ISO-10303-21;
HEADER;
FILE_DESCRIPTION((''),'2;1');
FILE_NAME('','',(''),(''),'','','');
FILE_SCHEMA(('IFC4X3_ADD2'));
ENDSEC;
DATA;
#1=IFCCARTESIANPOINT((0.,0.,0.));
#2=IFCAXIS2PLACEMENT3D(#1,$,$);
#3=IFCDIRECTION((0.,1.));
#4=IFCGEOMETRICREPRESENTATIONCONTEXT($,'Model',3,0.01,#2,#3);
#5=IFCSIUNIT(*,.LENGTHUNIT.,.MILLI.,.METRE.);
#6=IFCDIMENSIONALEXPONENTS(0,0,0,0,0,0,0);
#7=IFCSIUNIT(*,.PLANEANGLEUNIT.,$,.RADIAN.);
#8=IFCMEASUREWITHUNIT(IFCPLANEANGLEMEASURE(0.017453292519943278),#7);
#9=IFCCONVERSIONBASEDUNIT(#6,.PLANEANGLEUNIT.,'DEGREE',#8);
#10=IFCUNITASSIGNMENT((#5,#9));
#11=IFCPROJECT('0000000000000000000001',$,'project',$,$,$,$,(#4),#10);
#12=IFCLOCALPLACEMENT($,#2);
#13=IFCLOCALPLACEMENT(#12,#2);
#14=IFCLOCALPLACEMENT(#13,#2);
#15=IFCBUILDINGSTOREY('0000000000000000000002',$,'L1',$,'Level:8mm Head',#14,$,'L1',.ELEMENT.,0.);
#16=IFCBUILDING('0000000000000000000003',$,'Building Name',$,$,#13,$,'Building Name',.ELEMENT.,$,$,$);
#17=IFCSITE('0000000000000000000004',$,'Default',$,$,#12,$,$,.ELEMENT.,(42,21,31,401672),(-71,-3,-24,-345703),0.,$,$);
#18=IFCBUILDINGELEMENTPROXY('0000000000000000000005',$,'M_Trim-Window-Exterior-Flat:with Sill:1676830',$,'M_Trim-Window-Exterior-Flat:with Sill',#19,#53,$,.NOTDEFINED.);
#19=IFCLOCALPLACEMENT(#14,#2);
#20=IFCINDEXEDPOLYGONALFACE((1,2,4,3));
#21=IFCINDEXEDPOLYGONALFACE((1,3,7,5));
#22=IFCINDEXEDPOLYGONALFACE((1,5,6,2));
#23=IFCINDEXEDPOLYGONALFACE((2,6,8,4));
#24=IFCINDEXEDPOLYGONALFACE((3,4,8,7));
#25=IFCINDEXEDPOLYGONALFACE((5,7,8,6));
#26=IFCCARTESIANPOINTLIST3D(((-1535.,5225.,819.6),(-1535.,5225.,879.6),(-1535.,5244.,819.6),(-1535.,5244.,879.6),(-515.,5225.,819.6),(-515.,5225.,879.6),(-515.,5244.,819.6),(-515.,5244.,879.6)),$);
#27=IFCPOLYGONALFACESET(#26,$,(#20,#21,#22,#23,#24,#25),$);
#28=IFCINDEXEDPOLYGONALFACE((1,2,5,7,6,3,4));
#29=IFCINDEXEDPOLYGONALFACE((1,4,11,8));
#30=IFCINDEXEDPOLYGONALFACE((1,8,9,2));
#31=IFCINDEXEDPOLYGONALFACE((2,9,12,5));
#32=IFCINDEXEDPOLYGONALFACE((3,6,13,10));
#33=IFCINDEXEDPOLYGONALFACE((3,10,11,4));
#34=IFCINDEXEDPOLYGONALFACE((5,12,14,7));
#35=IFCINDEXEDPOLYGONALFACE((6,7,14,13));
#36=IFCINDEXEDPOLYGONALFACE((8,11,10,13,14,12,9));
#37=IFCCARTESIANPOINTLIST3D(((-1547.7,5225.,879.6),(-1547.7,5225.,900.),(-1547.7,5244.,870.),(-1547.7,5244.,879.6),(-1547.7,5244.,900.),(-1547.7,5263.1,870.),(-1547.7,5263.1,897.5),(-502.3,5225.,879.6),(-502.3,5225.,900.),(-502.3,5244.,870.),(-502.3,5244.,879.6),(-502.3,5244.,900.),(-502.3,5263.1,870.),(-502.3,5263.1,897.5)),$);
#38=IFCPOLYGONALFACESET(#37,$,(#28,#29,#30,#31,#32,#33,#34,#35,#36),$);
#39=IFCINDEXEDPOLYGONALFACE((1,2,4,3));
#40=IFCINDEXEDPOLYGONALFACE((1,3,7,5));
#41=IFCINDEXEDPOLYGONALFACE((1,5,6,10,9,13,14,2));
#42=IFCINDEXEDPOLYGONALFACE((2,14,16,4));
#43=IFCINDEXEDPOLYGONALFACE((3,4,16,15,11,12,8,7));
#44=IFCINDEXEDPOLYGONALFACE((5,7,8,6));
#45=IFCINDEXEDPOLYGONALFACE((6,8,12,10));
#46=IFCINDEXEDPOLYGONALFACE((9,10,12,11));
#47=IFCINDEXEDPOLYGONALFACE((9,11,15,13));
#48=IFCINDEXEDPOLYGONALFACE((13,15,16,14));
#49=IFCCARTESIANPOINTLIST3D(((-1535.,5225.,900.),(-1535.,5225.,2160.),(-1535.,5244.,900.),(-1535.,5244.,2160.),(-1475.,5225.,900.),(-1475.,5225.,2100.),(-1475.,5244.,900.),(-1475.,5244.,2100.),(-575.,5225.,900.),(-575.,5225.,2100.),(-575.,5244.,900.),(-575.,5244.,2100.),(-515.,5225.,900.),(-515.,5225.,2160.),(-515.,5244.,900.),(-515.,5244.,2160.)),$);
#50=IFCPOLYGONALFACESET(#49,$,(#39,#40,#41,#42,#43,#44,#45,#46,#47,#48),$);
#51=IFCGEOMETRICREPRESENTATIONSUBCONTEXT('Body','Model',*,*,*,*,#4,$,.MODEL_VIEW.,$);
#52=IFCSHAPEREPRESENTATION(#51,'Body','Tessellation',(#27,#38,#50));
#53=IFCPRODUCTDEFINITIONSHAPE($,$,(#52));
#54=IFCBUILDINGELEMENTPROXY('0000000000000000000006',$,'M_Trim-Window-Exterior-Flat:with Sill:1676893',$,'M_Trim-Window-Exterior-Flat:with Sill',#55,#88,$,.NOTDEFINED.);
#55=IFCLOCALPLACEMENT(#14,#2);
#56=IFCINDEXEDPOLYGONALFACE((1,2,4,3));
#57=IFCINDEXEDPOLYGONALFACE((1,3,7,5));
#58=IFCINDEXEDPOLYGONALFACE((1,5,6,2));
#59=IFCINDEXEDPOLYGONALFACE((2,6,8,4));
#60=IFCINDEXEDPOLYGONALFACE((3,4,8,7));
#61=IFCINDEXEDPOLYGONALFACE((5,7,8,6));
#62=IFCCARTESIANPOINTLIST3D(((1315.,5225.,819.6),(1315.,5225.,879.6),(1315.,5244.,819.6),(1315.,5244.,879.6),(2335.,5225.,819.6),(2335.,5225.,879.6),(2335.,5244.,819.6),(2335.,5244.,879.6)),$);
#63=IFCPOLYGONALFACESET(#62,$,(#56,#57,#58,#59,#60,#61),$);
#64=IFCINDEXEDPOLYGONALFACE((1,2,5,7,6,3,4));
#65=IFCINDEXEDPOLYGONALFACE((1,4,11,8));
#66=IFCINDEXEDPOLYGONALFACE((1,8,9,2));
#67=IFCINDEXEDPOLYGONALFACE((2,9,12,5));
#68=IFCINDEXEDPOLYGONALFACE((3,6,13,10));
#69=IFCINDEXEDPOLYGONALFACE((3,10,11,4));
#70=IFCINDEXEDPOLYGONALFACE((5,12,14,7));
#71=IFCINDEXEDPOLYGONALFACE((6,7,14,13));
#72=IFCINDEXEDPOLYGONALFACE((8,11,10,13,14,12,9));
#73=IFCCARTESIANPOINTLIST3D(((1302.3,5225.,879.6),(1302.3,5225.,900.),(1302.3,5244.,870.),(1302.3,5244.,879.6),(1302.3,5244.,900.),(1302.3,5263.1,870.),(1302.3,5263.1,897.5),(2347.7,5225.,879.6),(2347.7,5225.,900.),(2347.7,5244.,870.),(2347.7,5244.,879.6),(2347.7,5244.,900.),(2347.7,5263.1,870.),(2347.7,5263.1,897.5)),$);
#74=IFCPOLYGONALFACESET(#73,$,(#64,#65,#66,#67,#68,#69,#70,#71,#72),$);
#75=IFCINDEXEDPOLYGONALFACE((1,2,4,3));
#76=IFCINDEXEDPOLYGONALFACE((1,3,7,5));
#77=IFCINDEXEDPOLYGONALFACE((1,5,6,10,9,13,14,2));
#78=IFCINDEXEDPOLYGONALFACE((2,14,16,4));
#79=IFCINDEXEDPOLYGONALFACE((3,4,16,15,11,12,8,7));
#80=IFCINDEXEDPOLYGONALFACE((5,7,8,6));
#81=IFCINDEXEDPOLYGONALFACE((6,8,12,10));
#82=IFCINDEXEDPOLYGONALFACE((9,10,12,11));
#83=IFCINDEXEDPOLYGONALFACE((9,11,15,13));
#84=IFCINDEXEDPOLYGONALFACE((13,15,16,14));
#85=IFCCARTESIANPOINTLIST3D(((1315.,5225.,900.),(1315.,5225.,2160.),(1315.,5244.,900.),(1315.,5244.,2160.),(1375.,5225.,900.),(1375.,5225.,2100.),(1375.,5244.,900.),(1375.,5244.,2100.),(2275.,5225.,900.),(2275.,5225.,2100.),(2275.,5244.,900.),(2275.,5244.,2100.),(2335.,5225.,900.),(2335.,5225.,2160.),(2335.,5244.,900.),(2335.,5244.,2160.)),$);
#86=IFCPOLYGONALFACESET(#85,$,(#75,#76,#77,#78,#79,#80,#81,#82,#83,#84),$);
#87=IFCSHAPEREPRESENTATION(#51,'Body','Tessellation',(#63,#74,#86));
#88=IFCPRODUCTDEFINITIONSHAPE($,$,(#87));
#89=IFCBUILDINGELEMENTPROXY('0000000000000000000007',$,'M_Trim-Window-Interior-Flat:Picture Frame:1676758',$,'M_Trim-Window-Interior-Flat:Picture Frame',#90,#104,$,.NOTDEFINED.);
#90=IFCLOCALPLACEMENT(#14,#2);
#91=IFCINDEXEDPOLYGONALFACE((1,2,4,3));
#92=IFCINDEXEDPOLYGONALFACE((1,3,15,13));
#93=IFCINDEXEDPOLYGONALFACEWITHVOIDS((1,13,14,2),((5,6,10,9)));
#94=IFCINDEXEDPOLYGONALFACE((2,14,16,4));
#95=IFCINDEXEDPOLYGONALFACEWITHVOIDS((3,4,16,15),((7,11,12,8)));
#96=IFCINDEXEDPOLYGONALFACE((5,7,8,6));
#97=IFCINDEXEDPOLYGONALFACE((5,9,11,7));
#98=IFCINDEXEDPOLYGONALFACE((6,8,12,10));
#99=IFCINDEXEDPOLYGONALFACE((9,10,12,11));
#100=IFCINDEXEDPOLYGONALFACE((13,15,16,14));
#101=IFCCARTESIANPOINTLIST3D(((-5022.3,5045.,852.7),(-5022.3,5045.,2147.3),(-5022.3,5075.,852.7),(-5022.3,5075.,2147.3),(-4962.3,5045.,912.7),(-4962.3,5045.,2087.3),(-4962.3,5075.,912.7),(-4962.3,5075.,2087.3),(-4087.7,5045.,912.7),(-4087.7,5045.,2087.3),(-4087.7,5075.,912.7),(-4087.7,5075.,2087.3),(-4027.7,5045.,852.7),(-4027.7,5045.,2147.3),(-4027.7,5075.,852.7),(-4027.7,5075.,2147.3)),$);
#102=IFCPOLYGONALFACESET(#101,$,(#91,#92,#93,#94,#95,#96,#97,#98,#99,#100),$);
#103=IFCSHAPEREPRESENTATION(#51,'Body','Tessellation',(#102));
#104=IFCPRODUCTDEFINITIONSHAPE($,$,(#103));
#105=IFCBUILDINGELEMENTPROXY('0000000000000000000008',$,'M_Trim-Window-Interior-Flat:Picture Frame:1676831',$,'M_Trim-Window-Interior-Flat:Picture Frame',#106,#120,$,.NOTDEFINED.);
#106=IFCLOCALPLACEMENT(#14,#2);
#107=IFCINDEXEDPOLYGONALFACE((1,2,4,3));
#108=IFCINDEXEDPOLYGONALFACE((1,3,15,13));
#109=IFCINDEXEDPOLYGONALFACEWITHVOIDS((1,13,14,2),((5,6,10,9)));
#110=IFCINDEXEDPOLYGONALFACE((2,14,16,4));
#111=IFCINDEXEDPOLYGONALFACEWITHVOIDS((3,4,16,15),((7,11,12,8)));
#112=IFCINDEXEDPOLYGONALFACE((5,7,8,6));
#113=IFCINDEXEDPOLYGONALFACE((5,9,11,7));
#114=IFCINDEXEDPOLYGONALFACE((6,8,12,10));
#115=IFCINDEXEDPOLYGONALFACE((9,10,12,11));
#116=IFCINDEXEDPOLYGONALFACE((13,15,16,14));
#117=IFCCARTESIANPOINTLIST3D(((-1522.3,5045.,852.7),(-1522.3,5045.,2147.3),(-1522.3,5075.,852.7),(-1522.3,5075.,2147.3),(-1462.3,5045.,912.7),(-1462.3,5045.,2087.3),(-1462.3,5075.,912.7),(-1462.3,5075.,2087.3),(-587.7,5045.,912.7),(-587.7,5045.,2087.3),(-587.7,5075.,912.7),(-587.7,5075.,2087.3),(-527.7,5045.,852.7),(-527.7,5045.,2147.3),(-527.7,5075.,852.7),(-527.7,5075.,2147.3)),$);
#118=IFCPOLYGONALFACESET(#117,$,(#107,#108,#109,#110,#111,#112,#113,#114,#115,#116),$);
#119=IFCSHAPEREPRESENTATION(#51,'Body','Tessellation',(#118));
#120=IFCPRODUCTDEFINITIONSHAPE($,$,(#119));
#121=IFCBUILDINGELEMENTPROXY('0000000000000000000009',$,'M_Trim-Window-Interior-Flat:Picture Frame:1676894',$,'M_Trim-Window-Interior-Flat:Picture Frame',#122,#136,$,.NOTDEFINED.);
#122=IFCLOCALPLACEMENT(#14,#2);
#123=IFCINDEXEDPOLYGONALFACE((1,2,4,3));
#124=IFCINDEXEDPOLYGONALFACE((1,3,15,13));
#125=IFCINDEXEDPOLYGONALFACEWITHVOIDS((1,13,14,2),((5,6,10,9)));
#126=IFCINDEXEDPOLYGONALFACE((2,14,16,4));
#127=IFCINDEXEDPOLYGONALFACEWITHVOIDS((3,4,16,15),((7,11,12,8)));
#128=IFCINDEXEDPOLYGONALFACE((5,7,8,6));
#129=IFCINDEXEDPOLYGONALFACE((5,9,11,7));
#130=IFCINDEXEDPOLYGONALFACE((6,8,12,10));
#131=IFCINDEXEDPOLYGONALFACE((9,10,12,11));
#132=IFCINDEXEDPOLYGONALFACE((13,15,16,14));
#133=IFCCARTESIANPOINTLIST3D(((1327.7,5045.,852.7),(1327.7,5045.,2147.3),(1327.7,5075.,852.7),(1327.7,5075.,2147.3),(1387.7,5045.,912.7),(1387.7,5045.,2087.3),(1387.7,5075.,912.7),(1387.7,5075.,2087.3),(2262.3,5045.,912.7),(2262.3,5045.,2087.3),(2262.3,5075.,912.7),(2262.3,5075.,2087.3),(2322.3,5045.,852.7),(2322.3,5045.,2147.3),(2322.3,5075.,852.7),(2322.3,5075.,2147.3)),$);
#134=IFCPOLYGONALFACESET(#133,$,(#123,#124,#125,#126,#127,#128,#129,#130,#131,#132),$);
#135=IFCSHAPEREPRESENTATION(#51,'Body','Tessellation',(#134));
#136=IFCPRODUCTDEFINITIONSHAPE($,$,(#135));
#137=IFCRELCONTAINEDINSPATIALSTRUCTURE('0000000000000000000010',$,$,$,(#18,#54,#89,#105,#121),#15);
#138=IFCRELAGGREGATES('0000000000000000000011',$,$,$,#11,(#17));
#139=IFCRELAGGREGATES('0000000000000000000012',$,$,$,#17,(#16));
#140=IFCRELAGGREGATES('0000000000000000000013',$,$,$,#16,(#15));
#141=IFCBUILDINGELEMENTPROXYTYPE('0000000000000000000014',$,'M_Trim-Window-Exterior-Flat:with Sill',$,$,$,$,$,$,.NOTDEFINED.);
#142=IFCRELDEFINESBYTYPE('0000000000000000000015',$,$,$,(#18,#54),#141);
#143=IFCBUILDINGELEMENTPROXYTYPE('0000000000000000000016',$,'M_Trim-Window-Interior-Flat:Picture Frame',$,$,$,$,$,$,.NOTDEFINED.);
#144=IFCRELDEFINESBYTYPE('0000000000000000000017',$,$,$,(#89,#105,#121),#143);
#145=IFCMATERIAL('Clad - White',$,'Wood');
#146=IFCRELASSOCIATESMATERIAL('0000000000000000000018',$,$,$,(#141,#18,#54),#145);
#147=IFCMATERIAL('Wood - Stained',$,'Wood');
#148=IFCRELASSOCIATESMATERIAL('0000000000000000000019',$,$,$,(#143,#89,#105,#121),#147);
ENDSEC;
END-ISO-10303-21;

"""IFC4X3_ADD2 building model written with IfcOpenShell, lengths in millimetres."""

from ifc_helpers import new_model, entity, si_unit, converted_unit, direction, frame, frame_2d, origin, place, context, subcontext, project, spatial, polyline, rectangle, outline, extrude, source, transform, mapped, material, type_object, type_shapes, element, save


model = new_model("IFC4X3_ADD2")

# Units and contexts
model_context = context("Model", 3, precision=0.01, world=origin(), true_north=direction((0.0, 1.0)))
body_context = subcontext(model_context, "Body", "Model", "MODEL_VIEW")
ifc_project = project(units=[si_unit("LENGTHUNIT", "METRE", prefix="MILLI"), converted_unit("PLANEANGLEUNIT", "DEGREE", entity("IfcPlaneAngleMeasure", 0.017453292519943278), si_unit("PLANEANGLEUNIT", "RADIAN"), dimensions=[0, 0, 0, 0, 0, 0, 0])], contexts=[model_context])

# Site, building, storey
site_placement = place(None, origin())
site = spatial("IfcSite", under=ifc_project, at=site_placement, Name="Default", CompositionType="ELEMENT", RefLatitude=(42, 21, 31, 401672), RefLongitude=(-71, -3, -24, -345703), RefElevation=0.0)
building_placement = place(site_placement, origin())
building = spatial("IfcBuilding", under=site, at=building_placement, Name="Building Name", LongName="Building Name", CompositionType="ELEMENT")
storey_placement = place(building_placement, origin())
storey = spatial("IfcBuildingStorey", under=building, at=storey_placement, Name="L1", ObjectType="Level:8mm Head", LongName="L1", CompositionType="ELEMENT", Elevation=0.0)

# Building element proxies
ifc_material_1 = material(Name="Clad - White", Category="Wood")
ifc_material_2 = material(Name="Wood - Stained", Category="Wood")
building_element_proxy_type_1 = type_object("IfcBuildingElementProxyType", Name="M_Trim-Window-Exterior-Flat:with Sill", PredefinedType="NOTDEFINED", material=ifc_material_1)
shared_shape_1 = source(origin(), body_context, "Body", "SweptSolid", [
    extrude(rectangle(XDim=1020.0, YDim=60.0, at=frame_2d((0.0, 0.0), x_axis=(1.0, 0.0))), frame((0.0, -1250.4, 0.0), z_axis=(0.0, 0.0, 1.0), x_axis=(-1.0, 0.0, 0.0)), (0.0, 0.0, 1.0), 19.0),
    extrude(outline(polyline([(-19.0, -15.2), (0.0, -15.2), (0.0, -5.7), (19.0, -5.7), (19.0, 14.8), (0.0, 14.8), (-19.0, 12.3), (-19.0, -15.2)])), frame((-522.7, -1214.8, 19.0), z_axis=(1.0, 0.0, 0.0), x_axis=(0.0, 0.0, -1.0)), (0.0, 0.0, 1.0), 1045.4),
    extrude(outline(polyline([(-645.0, -510.0), (615.0, -510.0), (615.0, -450.0), (-585.0, -450.0), (-585.0, 450.0), (615.0, 450.0), (615.0, 510.0), (-645.0, 510.0), (-645.0, -510.0)])), frame((0.0, -585.0, 0.0), z_axis=(0.0, 0.0, 1.0), x_axis=(0.0, -1.0, 0.0)), (0.0, 0.0, 1.0), 19.0),
])
type_shapes(building_element_proxy_type_1, [shared_shape_1])
for number, where, z_axis, x_axis, name in (
    (1, (-1025.0, 5225.0, 2100.0), (0.0, 1.0, 0.0), (-1.0, 0.0, 0.0), "M_Trim-Window-Exterior-Flat:with Sill:1676830"),
    (2, (1825.0, 5225.0, 2100.0), (0.0, 1.0, 0.0), (-1.0, 0.0, 0.0), "M_Trim-Window-Exterior-Flat:with Sill:1676893"),
):
    element("IfcBuildingElementProxy", number, at=place(storey_placement, frame(where, z_axis=z_axis, x_axis=x_axis)), inside=storey, type_object=building_element_proxy_type_1, material=ifc_material_1, Name=name, ObjectType="M_Trim-Window-Exterior-Flat:with Sill", PredefinedType="NOTDEFINED", context=body_context, shape_type="MappedRepresentation", body=[
        mapped(shared_shape_1, transform((0.0, 0.0, 0.0), scale=1.0)),
    ])
building_element_proxy_type_2 = type_object("IfcBuildingElementProxyType", Name="M_Trim-Window-Interior-Flat:Picture Frame", PredefinedType="NOTDEFINED", material=ifc_material_2)
shared_shape_2 = source(origin(), body_context, "Body", "SweptSolid", [
    extrude(outline(polyline([(-497.3, -647.3), (497.3, -647.3), (497.3, 647.3), (-497.3, 647.3), (-497.3, -647.3)]), holes=[polyline([(-437.3, -587.3), (-437.3, 587.3), (437.3, 587.3), (437.3, -587.3), (-437.3, -587.3)])]), frame((0.0, -600.0, 0.0), z_axis=(0.0, 0.0, 1.0), x_axis=(-1.0, 0.0, 0.0)), (0.0, 0.0, 1.0), 30.0),
])
type_shapes(building_element_proxy_type_2, [shared_shape_2])
for number, where, z_axis, x_axis, name in (
    (3, (-4525.0, 5075.0, 2100.0), (0.0, -1.0, 0.0), (1.0, 0.0, 0.0), "M_Trim-Window-Interior-Flat:Picture Frame:1676758"),
    (4, (-1025.0, 5075.0, 2100.0), (0.0, -1.0, 0.0), (1.0, 0.0, 0.0), "M_Trim-Window-Interior-Flat:Picture Frame:1676831"),
    (5, (1825.0, 5075.0, 2100.0), (0.0, -1.0, 0.0), (1.0, 0.0, 0.0), "M_Trim-Window-Interior-Flat:Picture Frame:1676894"),
):
    element("IfcBuildingElementProxy", number, at=place(storey_placement, frame(where, z_axis=z_axis, x_axis=x_axis)), inside=storey, type_object=building_element_proxy_type_2, material=ifc_material_2, Name=name, ObjectType="M_Trim-Window-Interior-Flat:Picture Frame", PredefinedType="NOTDEFINED", context=body_context, shape_type="MappedRepresentation", body=[
        mapped(shared_shape_2, transform((0.0, 0.0, 0.0), scale=1.0)),
    ])

save(model, "model.ifc")
